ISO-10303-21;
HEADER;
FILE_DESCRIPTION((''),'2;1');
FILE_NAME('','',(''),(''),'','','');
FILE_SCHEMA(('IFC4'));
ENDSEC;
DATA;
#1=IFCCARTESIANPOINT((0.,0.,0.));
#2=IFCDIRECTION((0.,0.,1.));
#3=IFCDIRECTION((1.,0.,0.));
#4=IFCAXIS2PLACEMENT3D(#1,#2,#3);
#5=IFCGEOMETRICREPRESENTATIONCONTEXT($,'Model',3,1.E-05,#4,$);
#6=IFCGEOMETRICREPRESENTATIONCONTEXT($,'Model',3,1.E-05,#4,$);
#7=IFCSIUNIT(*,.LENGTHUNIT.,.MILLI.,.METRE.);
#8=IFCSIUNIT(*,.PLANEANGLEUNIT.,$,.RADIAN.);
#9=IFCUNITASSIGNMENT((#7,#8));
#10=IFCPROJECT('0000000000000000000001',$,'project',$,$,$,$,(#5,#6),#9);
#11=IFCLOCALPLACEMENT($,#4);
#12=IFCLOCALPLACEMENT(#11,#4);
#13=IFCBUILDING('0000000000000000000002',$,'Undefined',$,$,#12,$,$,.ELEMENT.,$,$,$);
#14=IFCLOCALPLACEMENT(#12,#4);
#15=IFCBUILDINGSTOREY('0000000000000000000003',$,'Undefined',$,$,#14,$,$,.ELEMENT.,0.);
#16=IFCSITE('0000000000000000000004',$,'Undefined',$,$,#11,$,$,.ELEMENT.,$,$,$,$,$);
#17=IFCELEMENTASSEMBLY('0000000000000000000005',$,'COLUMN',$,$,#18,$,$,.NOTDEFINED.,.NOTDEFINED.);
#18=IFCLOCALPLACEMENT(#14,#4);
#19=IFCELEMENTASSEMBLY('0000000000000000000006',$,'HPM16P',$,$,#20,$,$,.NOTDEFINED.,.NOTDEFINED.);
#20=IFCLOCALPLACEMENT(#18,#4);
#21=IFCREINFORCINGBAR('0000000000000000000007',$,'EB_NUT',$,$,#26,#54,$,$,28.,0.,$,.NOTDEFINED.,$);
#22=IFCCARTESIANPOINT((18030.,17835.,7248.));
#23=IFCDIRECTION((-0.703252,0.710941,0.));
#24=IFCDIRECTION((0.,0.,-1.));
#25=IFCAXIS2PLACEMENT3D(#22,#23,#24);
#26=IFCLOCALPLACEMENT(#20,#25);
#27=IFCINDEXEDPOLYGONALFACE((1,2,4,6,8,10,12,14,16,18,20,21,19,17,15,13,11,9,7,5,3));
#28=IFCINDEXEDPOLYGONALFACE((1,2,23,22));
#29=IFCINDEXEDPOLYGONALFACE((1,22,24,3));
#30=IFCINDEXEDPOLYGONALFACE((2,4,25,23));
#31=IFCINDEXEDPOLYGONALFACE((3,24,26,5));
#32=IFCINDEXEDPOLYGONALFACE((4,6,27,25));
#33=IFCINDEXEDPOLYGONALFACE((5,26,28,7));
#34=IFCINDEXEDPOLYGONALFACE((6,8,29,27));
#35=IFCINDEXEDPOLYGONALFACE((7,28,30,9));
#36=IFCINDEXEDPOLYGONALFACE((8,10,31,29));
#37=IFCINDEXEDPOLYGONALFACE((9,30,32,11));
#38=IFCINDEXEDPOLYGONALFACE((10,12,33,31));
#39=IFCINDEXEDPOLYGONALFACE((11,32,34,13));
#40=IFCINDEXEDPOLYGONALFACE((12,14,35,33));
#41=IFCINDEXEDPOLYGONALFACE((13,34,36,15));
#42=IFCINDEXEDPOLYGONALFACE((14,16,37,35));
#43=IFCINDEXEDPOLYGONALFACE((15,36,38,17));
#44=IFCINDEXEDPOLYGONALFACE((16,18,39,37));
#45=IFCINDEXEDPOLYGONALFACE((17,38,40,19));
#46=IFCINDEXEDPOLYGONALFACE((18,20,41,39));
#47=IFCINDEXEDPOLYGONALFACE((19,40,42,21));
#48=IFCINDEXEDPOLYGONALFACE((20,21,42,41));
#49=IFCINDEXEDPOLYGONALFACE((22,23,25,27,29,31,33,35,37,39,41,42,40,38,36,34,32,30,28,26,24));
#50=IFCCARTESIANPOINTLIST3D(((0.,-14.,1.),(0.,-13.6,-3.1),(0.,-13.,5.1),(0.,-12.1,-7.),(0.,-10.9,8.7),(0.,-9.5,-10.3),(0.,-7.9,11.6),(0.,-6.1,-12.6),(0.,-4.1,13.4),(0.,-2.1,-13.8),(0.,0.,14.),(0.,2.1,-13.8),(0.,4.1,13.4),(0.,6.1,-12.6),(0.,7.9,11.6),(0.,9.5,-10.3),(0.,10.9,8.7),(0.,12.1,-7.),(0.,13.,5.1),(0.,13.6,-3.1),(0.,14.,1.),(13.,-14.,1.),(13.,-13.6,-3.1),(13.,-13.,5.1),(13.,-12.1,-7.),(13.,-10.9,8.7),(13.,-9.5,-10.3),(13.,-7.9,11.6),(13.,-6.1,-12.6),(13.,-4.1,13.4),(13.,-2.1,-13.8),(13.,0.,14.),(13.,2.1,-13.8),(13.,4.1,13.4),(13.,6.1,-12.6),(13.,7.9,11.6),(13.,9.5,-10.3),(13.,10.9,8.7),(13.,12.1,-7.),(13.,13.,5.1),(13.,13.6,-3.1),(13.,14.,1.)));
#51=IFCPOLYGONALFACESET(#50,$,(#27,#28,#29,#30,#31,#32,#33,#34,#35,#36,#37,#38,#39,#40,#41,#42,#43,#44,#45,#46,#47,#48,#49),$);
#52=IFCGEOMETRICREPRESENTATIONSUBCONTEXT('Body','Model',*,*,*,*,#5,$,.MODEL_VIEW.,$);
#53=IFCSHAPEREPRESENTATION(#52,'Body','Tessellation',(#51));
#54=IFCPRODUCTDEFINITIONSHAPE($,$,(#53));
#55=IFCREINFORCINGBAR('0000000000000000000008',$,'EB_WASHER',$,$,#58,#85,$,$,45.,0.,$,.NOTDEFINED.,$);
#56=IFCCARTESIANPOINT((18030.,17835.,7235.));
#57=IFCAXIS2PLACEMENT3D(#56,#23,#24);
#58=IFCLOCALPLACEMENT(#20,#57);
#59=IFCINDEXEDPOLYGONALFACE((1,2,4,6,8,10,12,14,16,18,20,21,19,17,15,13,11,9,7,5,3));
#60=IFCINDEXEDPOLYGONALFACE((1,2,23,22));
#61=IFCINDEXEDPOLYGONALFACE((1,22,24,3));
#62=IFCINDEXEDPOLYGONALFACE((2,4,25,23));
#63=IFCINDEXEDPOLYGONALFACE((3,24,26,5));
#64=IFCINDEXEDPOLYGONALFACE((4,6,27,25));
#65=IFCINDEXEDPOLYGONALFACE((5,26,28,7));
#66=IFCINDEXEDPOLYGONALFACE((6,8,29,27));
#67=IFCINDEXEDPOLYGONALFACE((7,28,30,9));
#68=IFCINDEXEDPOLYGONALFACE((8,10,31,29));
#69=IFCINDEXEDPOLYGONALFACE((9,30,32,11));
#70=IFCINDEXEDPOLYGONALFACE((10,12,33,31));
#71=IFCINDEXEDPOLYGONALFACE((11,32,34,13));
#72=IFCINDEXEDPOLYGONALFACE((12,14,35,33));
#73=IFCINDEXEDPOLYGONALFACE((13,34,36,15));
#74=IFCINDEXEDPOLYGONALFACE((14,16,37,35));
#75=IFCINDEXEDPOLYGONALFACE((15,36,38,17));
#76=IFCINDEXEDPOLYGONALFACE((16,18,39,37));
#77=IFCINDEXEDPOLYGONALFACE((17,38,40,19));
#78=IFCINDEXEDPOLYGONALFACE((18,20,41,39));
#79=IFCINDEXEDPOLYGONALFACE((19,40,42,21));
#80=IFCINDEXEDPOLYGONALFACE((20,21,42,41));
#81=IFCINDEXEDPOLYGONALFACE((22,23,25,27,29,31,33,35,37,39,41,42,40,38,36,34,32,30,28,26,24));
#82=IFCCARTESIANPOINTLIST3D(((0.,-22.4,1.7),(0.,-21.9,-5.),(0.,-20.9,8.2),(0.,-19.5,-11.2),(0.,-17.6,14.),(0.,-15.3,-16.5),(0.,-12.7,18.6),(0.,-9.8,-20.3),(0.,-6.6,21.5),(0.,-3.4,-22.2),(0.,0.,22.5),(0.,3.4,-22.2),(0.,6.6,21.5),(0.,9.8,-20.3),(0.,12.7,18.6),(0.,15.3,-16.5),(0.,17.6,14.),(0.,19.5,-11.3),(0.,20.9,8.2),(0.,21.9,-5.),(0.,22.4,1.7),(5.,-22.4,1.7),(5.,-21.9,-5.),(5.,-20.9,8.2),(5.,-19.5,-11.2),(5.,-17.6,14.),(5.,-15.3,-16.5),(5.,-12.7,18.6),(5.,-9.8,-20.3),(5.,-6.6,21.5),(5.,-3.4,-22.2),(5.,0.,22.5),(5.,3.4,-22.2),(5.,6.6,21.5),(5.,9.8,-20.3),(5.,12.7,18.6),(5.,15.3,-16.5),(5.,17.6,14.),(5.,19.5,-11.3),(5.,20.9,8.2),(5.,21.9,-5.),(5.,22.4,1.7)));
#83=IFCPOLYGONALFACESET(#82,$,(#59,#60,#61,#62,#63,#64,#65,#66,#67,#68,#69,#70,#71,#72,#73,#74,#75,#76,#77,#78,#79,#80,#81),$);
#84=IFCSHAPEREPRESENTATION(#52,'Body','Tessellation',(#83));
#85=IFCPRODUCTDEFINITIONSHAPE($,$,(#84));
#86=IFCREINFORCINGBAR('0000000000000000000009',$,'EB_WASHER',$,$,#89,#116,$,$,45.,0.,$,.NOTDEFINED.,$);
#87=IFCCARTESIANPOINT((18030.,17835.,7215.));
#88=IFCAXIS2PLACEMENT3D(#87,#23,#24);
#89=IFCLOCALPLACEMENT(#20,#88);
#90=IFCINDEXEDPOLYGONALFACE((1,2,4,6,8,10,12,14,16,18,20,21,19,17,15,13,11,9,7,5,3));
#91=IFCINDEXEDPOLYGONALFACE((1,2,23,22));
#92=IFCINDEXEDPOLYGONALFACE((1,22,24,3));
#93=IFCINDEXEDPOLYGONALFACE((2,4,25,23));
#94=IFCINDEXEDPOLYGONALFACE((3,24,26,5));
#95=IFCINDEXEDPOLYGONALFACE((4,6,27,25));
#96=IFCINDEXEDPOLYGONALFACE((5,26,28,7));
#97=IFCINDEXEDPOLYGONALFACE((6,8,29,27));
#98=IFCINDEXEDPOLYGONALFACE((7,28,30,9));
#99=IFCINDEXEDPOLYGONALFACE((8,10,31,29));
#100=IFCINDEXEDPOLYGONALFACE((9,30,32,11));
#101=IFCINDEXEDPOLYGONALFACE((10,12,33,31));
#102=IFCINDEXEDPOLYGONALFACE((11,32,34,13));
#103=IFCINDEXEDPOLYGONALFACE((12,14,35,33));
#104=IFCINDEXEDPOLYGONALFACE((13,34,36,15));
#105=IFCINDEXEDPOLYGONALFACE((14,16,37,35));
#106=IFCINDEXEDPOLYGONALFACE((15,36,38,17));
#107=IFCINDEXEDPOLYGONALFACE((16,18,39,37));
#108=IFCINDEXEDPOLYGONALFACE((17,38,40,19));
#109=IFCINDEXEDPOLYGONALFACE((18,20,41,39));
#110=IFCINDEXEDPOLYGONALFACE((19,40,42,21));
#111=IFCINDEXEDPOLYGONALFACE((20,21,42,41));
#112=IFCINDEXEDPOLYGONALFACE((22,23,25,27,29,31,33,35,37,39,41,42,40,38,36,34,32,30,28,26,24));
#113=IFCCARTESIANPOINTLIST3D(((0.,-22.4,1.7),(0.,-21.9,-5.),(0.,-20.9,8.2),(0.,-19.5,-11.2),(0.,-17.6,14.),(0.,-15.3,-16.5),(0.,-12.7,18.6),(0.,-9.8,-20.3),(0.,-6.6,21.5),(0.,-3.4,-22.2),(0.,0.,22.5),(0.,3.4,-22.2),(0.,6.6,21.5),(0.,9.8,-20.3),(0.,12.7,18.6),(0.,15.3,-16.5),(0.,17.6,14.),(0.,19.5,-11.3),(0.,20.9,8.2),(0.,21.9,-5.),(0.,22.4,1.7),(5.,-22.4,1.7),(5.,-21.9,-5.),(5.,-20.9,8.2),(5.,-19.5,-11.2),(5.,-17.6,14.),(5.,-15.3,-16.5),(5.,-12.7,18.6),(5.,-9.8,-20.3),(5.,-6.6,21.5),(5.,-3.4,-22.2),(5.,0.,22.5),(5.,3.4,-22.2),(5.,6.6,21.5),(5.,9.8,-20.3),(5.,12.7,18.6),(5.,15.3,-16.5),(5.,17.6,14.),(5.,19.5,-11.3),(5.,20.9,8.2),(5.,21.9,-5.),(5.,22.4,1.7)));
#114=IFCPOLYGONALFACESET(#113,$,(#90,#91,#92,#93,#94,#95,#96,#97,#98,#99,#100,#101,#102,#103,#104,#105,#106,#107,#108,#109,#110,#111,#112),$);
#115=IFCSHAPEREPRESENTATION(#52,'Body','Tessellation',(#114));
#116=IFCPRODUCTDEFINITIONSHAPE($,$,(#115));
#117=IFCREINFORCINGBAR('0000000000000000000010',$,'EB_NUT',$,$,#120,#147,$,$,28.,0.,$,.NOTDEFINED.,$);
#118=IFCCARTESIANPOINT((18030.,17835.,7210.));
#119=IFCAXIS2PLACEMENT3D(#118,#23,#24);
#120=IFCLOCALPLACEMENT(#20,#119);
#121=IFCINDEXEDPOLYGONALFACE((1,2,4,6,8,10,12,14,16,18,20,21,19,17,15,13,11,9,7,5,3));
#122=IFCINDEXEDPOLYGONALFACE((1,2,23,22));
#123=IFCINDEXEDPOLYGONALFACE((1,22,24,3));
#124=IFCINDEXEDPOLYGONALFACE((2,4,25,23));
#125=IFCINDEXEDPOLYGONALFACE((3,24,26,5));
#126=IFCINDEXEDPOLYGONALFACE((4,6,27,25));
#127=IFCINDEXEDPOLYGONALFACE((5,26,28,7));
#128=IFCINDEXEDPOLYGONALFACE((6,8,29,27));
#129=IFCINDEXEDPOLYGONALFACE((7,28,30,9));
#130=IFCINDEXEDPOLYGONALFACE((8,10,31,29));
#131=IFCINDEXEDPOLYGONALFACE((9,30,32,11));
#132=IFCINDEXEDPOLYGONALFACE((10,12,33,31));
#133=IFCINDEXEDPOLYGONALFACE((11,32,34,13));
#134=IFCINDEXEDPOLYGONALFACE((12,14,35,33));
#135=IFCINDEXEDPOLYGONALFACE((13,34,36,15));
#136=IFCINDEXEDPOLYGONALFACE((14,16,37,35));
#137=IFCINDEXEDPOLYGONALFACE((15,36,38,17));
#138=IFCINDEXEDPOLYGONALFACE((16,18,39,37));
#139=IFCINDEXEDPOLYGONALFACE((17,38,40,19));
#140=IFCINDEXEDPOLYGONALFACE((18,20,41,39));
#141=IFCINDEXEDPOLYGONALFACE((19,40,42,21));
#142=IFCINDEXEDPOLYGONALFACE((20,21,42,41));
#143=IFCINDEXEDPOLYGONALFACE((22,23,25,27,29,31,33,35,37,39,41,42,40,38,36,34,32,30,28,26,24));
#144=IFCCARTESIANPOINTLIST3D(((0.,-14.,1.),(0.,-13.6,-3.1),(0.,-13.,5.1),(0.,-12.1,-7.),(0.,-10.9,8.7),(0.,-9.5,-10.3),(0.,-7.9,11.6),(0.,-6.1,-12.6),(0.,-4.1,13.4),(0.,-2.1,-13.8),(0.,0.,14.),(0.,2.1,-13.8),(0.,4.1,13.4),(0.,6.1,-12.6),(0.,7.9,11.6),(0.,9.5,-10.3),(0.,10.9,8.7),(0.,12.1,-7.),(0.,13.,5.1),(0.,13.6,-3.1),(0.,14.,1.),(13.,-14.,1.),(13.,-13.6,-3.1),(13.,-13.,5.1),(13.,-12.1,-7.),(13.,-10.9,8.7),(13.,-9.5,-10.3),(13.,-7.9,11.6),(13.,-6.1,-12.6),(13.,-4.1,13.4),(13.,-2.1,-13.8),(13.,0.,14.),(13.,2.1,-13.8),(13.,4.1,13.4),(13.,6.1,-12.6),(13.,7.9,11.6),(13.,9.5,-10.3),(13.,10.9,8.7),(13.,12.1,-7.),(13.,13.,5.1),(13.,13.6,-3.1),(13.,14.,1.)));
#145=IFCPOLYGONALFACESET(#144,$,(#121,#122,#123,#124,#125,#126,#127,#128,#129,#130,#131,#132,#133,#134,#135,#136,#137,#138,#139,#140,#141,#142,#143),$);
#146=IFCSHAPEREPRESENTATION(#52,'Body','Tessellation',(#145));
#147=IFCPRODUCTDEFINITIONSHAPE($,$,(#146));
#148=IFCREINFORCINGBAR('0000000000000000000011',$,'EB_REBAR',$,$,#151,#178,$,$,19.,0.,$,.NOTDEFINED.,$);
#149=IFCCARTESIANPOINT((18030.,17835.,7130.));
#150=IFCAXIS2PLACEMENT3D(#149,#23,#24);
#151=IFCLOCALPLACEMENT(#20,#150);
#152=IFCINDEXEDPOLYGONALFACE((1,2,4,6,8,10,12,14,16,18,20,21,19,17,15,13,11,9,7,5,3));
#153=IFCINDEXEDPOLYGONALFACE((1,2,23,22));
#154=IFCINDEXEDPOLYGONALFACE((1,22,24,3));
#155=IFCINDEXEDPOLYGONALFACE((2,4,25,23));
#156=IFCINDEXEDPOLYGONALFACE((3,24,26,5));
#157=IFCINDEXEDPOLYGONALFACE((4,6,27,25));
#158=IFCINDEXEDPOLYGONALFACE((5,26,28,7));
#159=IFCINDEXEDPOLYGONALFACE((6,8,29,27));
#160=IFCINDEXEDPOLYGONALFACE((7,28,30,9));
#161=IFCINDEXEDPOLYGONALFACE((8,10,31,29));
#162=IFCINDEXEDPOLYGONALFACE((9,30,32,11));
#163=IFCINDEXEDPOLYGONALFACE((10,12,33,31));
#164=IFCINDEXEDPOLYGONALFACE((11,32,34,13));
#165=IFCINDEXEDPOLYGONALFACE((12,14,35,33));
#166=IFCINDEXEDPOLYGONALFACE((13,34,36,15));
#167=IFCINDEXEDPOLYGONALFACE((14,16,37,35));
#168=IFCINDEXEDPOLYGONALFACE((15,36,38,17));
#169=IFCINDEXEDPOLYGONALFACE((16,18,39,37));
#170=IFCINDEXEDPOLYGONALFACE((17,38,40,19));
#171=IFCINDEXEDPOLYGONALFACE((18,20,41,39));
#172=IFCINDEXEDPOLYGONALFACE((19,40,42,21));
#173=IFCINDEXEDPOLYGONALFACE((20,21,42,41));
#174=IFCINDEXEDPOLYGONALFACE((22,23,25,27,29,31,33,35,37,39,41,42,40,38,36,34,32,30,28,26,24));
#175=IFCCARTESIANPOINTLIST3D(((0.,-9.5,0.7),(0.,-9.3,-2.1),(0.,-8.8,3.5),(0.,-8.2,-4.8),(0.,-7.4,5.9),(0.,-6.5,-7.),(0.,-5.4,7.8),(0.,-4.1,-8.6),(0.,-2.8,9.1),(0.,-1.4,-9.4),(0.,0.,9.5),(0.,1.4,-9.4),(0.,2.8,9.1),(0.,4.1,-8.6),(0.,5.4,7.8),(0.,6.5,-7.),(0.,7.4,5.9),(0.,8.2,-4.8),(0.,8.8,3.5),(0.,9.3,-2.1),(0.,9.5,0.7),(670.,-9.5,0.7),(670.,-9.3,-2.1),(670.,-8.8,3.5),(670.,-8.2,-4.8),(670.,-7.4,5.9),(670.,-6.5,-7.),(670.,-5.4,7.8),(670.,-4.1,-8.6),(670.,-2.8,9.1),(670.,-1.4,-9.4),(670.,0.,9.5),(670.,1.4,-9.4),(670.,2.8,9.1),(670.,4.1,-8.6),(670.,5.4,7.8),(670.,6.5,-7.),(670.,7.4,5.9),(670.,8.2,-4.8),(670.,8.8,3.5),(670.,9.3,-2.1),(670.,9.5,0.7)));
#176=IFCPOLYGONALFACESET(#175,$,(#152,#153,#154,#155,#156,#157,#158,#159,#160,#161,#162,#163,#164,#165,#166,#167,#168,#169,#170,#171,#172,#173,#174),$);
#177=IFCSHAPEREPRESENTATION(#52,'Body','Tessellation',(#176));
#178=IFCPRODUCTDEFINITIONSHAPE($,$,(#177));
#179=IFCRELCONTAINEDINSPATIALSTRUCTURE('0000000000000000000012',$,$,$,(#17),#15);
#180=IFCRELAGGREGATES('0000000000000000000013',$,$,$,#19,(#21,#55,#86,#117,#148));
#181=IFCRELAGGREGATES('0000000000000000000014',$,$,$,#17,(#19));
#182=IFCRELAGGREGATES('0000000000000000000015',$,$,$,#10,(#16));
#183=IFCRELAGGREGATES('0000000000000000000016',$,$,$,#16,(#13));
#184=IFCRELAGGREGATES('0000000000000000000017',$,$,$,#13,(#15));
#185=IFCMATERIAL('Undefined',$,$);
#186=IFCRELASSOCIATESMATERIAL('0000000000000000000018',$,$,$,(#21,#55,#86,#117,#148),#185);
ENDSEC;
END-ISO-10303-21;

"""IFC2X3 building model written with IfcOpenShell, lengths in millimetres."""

from ifc_helpers import new_model, entity, si_unit, frame, origin_with_axes, place, context, subcontext, project, spatial, source, transform, mapped, material, element, aggregate, save


model = new_model("IFC2X3")

# Units and contexts
model_context_1 = context("Model", 3, precision=1e-05, world=origin_with_axes())
model_context_2 = context("Model", 3, precision=1e-05, world=origin_with_axes())
body_context = subcontext(model_context_1, "Body", "Model", "MODEL_VIEW")
ifc_project = project(units=[si_unit("LENGTHUNIT", "METRE", prefix="MILLI"), si_unit("PLANEANGLEUNIT", "RADIAN")], contexts=[model_context_1, model_context_2])

# Site, building, storey
site_placement = place(None, origin_with_axes())
site = spatial("IfcSite", under=ifc_project, at=site_placement, Name="Undefined", CompositionType="ELEMENT")
building_placement = place(site_placement, origin_with_axes())
building = spatial("IfcBuilding", under=site, at=building_placement, Name="Undefined", CompositionType="ELEMENT")
storey_placement = place(building_placement, origin_with_axes())
storey = spatial("IfcBuildingStorey", under=building, at=storey_placement, Name="Undefined", CompositionType="ELEMENT", Elevation=0.0)

# Element assemblies
assembly_1_placement = place(storey_placement, origin_with_axes())
assembly_1 = element("IfcElementAssembly", 1, at=assembly_1_placement, inside=storey, Name="COLUMN", AssemblyPlace="NOTDEFINED", PredefinedType="NOTDEFINED")
assembly_2_placement = place(assembly_1_placement, origin_with_axes())
assembly_2 = element("IfcElementAssembly", 2, at=assembly_2_placement, Name="HPM16P", AssemblyPlace="NOTDEFINED", PredefinedType="NOTDEFINED")

# Shared definitions
ifc_material_1 = material(Name="Undefined")

# Reinforcing bars
shared_shape_1 = source(origin_with_axes(), body_context, "Body", "AdvancedSweptSolid", [
    entity("IfcSweptDiskSolid", entity("IfcTrimmedCurve", entity("IfcLine", entity("IfcCartesianPoint", [0.0, 0.0, 0.0]), entity("IfcVector", entity("IfcDirection", [1.0, 0.0, 0.0]), 1.0)), [entity("IfcParameterValue", 0.0)], [entity("IfcParameterValue", 13.0)], True, "PARAMETER"), 14.0, None, 0.0, 13.0),
])
reinforcing_bar_1_placement = place(assembly_2_placement, frame((18030.0, 17835.0, 7248.0), z_axis=(-0.703252, 0.710941, 0.0), x_axis=(0.0, 0.0, -1.0)))
reinforcing_bar_1 = element("IfcReinforcingBar", 3, at=reinforcing_bar_1_placement, material=ifc_material_1, Name="EB_NUT", BarRole="NOTDEFINED", CrossSectionArea=0.0, NominalDiameter=28.0, context=body_context, shape_type="MappedRepresentation", body=[
    mapped(shared_shape_1, transform((0.0, 0.0, 0.0))),
])
shared_shape_2 = source(origin_with_axes(), body_context, "Body", "AdvancedSweptSolid", [
    entity("IfcSweptDiskSolid", entity("IfcTrimmedCurve", entity("IfcLine", entity("IfcCartesianPoint", [0.0, 0.0, 0.0]), entity("IfcVector", entity("IfcDirection", [1.0, 0.0, 0.0]), 1.0)), [entity("IfcParameterValue", 0.0)], [entity("IfcParameterValue", 5.0)], True, "PARAMETER"), 22.5, None, 0.0, 5.0),
])
reinforcing_bar_2_placement = place(assembly_2_placement, frame((18030.0, 17835.0, 7235.0), z_axis=(-0.703252, 0.710941, 0.0), x_axis=(0.0, 0.0, -1.0)))
reinforcing_bar_2 = element("IfcReinforcingBar", 4, at=reinforcing_bar_2_placement, material=ifc_material_1, Name="EB_WASHER", BarRole="NOTDEFINED", CrossSectionArea=0.0, NominalDiameter=45.0, context=body_context, shape_type="MappedRepresentation", body=[
    mapped(shared_shape_2, transform((0.0, 0.0, 0.0))),
])
shared_shape_3 = source(origin_with_axes(), body_context, "Body", "AdvancedSweptSolid", [
    entity("IfcSweptDiskSolid", entity("IfcTrimmedCurve", entity("IfcLine", entity("IfcCartesianPoint", [0.0, 0.0, 0.0]), entity("IfcVector", entity("IfcDirection", [1.0, 0.0, 0.0]), 1.0)), [entity("IfcParameterValue", 0.0)], [entity("IfcParameterValue", 5.0)], True, "PARAMETER"), 22.5, None, 0.0, 5.0),
])
reinforcing_bar_3_placement = place(assembly_2_placement, frame((18030.0, 17835.0, 7215.0), z_axis=(-0.703252, 0.710941, 0.0), x_axis=(0.0, 0.0, -1.0)))
reinforcing_bar_3 = element("IfcReinforcingBar", 5, at=reinforcing_bar_3_placement, material=ifc_material_1, Name="EB_WASHER", BarRole="NOTDEFINED", CrossSectionArea=0.0, NominalDiameter=45.0, context=body_context, shape_type="MappedRepresentation", body=[
    mapped(shared_shape_3, transform((0.0, 0.0, 0.0))),
])
shared_shape_4 = source(origin_with_axes(), body_context, "Body", "AdvancedSweptSolid", [
    entity("IfcSweptDiskSolid", entity("IfcTrimmedCurve", entity("IfcLine", entity("IfcCartesianPoint", [0.0, 0.0, 0.0]), entity("IfcVector", entity("IfcDirection", [1.0, 0.0, 0.0]), 1.0)), [entity("IfcParameterValue", 0.0)], [entity("IfcParameterValue", 13.0)], True, "PARAMETER"), 14.0, None, 0.0, 13.0),
])
reinforcing_bar_4_placement = place(assembly_2_placement, frame((18030.0, 17835.0, 7210.0), z_axis=(-0.703252, 0.710941, 0.0), x_axis=(0.0, 0.0, -1.0)))
reinforcing_bar_4 = element("IfcReinforcingBar", 6, at=reinforcing_bar_4_placement, material=ifc_material_1, Name="EB_NUT", BarRole="NOTDEFINED", CrossSectionArea=0.0, NominalDiameter=28.0, context=body_context, shape_type="MappedRepresentation", body=[
    mapped(shared_shape_4, transform((0.0, 0.0, 0.0))),
])
shared_shape_5 = source(origin_with_axes(), body_context, "Body", "AdvancedSweptSolid", [
    entity("IfcSweptDiskSolid", entity("IfcTrimmedCurve", entity("IfcLine", entity("IfcCartesianPoint", [0.0, 0.0, 0.0]), entity("IfcVector", entity("IfcDirection", [1.0, 0.0, 0.0]), 1.0)), [entity("IfcParameterValue", 0.0)], [entity("IfcParameterValue", 670.0)], True, "PARAMETER"), 9.5, None, 0.0, 670.0),
])
reinforcing_bar_5_placement = place(assembly_2_placement, frame((18030.0, 17835.0, 7130.0), z_axis=(-0.703252, 0.710941, 0.0), x_axis=(0.0, 0.0, -1.0)))
reinforcing_bar_5 = element("IfcReinforcingBar", 7, at=reinforcing_bar_5_placement, material=ifc_material_1, Name="EB_REBAR", BarRole="NOTDEFINED", CrossSectionArea=0.0, NominalDiameter=19.0, context=body_context, shape_type="MappedRepresentation", body=[
    mapped(shared_shape_5, transform((0.0, 0.0, 0.0))),
])
aggregate(assembly_2, [reinforcing_bar_1, reinforcing_bar_2, reinforcing_bar_3, reinforcing_bar_4, reinforcing_bar_5])

aggregate(assembly_1, [assembly_2])

save(model, "model.ifc")
